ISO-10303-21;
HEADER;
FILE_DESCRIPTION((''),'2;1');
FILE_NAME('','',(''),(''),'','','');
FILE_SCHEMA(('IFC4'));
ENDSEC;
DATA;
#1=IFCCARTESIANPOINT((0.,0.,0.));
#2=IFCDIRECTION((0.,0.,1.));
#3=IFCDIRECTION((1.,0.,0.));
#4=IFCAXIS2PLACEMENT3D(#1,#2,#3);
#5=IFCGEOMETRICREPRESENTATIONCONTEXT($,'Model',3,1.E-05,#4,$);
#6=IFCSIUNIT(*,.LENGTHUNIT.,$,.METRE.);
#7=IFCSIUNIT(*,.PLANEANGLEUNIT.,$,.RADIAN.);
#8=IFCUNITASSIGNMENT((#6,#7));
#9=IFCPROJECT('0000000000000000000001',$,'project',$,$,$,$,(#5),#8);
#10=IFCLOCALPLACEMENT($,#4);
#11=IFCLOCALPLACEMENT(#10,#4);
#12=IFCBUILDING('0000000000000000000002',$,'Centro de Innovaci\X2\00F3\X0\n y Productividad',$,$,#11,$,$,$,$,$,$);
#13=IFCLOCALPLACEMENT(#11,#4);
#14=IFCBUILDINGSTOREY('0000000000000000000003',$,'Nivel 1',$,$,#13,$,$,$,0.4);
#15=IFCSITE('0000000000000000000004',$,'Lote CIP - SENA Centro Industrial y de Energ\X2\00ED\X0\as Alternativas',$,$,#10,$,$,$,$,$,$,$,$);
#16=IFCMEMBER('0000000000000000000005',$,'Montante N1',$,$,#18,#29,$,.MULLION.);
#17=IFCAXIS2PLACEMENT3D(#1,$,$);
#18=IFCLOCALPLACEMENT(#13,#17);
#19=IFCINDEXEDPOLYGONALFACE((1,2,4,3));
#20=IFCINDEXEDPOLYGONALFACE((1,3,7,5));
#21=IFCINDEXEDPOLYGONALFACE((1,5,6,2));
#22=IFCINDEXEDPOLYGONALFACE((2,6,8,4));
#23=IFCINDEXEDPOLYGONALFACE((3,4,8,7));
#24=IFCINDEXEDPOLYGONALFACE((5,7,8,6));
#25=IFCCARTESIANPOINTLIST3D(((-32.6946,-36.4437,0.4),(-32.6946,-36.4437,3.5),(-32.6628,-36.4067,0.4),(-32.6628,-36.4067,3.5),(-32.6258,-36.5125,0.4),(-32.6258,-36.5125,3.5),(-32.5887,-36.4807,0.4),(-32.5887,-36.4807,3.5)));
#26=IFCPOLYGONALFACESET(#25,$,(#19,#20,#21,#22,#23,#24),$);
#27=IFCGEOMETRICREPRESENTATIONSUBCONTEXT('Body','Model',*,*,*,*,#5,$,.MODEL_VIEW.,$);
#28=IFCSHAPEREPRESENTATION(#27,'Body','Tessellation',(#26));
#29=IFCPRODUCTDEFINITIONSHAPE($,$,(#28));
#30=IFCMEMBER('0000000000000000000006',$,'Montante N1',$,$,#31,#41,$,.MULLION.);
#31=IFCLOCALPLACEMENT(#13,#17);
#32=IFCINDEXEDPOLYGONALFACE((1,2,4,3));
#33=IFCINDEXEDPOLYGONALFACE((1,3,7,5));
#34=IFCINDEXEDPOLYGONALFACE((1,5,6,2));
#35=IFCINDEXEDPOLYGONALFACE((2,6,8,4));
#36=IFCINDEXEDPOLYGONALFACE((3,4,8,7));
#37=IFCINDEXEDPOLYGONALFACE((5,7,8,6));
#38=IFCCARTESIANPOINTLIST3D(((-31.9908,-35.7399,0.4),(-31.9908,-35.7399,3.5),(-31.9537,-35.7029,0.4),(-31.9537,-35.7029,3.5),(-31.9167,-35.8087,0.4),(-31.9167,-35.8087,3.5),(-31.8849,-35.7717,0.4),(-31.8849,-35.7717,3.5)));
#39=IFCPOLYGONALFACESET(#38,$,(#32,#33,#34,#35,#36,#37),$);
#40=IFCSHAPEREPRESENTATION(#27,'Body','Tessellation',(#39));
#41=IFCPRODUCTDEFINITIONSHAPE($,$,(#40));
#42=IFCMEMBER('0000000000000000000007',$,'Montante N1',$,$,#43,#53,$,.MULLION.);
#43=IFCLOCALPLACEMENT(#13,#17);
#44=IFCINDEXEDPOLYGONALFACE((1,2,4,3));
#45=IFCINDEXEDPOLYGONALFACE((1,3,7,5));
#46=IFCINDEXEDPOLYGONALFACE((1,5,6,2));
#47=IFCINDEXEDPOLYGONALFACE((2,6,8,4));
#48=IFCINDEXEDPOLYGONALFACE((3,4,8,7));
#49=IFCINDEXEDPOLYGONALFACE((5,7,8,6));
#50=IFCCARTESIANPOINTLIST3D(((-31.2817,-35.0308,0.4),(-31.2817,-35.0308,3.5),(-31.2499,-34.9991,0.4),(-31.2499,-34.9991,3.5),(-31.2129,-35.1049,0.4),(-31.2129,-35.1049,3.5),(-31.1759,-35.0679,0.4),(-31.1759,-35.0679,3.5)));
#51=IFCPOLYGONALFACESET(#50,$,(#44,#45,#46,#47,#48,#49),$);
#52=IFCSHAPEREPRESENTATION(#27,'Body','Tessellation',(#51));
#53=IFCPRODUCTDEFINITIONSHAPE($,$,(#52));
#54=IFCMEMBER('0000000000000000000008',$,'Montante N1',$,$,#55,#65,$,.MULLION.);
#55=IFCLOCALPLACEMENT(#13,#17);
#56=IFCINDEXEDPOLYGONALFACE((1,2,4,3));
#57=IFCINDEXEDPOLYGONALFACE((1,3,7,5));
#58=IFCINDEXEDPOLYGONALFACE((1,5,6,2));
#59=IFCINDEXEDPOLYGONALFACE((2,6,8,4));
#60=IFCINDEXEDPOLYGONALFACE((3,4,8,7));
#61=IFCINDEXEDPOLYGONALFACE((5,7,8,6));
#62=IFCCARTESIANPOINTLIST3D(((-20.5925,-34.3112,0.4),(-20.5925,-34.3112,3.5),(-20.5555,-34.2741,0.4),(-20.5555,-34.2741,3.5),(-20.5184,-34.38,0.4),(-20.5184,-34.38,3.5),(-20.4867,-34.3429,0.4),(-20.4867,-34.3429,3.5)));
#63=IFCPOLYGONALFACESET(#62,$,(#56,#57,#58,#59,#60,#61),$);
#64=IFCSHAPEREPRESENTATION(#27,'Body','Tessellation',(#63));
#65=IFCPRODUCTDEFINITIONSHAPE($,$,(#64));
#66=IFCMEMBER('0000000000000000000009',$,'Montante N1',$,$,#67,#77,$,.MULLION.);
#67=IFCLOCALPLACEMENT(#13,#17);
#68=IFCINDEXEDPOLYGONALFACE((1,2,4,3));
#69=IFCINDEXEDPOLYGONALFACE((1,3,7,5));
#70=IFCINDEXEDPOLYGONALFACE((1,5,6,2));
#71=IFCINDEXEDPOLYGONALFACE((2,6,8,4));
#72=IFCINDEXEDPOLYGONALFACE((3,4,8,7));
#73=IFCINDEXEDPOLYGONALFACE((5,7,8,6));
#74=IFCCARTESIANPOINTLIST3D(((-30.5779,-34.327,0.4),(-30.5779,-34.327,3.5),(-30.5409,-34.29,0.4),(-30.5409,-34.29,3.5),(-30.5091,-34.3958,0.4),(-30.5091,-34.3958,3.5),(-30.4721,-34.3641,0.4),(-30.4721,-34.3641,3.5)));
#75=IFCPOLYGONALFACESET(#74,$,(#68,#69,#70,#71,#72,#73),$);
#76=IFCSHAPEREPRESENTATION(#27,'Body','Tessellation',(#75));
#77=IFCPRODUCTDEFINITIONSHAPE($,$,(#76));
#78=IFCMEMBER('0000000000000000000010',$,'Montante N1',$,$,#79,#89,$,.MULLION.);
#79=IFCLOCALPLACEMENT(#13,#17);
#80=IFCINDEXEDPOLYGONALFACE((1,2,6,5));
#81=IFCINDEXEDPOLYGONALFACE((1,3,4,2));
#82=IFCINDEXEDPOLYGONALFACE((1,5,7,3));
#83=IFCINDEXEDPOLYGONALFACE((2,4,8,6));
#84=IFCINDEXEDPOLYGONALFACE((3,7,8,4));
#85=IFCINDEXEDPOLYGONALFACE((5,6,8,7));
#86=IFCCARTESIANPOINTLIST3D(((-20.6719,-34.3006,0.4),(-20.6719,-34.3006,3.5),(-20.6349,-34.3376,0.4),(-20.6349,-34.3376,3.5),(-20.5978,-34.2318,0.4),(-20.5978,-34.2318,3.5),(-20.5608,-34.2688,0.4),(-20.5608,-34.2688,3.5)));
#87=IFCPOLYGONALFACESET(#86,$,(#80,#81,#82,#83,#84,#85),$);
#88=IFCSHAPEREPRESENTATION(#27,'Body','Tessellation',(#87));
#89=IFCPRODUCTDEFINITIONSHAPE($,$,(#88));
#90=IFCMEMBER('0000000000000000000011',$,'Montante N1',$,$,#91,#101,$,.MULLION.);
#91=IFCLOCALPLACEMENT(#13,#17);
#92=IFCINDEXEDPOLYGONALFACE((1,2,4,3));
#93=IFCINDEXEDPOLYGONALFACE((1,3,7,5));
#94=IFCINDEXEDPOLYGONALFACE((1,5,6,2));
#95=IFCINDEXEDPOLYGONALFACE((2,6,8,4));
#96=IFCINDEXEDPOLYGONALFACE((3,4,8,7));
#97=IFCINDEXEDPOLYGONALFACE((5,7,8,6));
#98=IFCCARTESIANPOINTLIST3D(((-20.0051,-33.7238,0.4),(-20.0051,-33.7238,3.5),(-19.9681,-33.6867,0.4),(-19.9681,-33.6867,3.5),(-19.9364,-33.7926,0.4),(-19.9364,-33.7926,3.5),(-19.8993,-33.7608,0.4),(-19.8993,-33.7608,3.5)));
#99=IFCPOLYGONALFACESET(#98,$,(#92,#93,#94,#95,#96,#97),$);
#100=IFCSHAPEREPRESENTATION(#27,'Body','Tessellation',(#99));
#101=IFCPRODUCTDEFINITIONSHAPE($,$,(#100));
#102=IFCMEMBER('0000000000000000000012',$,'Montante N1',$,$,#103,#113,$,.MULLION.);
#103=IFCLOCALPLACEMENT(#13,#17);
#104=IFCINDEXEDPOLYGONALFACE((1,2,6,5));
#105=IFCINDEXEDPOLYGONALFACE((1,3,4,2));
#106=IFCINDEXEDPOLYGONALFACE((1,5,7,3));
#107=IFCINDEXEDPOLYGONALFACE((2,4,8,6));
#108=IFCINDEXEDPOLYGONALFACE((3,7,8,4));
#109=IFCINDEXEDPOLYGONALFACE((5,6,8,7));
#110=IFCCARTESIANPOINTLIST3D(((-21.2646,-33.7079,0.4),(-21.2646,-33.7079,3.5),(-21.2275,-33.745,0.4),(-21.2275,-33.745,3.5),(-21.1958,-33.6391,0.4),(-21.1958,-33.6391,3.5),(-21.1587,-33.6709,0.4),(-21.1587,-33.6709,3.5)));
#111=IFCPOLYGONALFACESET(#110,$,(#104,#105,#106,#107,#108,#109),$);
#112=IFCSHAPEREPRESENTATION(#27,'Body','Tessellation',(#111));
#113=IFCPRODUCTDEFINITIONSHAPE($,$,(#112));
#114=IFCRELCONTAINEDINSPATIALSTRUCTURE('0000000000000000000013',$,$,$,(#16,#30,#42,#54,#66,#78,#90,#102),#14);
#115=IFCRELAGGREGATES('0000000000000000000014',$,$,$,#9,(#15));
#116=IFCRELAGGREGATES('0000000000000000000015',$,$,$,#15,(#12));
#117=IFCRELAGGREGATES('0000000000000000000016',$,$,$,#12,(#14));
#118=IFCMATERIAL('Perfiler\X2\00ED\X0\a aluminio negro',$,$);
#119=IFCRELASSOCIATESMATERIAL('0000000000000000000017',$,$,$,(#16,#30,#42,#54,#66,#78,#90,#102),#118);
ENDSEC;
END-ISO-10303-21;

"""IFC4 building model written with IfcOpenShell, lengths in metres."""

from ifc_helpers import new_model, si_unit, frame, origin_with_axes, place, context, subcontext, project, spatial, polyline, outline, extrude, material, element, save


model = new_model("IFC4")

# Units and contexts
model_context = context("Model", 3, precision=1e-05, world=origin_with_axes())
body_context = subcontext(model_context, "Body", "Model", "MODEL_VIEW")
ifc_project = project(units=[si_unit("LENGTHUNIT", "METRE"), si_unit("PLANEANGLEUNIT", "RADIAN")], contexts=[model_context])

# Site, building, storey
site_placement = place(None, origin_with_axes())
site = spatial("IfcSite", under=ifc_project, at=site_placement, Name="Lote CIP - SENA Centro Industrial y de Energías Alternativas")
building_placement = place(site_placement, origin_with_axes())
building = spatial("IfcBuilding", under=site, at=building_placement, Name="Centro de Innovación y Productividad")
storey_placement = place(building_placement, origin_with_axes())
storey = spatial("IfcBuildingStorey", under=building, at=storey_placement, Name="Nivel 1", Elevation=0.4)

# Members
ifc_material = material(Name="Perfilería aluminio negro")
member_1_placement = place(storey_placement, origin_with_axes())
element("IfcMember", 1, at=member_1_placement, inside=storey, material=ifc_material, Name="Montante N1", PredefinedType="MULLION", context=body_context, shape_type="SweptSolid", body=[
    extrude(outline(polyline([(-32.6946, -36.4437), (-32.6628, -36.4067), (-32.5887, -36.4807), (-32.6258, -36.5125), (-32.6946, -36.4437)])), frame((0.0, 0.0, 0.4)), (0.0, 0.0, 1.0), 3.1),
])
member_2_placement = place(storey_placement, origin_with_axes())
element("IfcMember", 2, at=member_2_placement, inside=storey, material=ifc_material, Name="Montante N1", PredefinedType="MULLION", context=body_context, shape_type="SweptSolid", body=[
    extrude(outline(polyline([(-31.9167, -35.8087), (-31.9908, -35.7399), (-31.9537, -35.7029), (-31.8849, -35.7717), (-31.9167, -35.8087)])), frame((0.0, 0.0, 0.4)), (0.0, 0.0, 1.0), 3.1),
])
member_3_placement = place(storey_placement, origin_with_axes())
element("IfcMember", 3, at=member_3_placement, inside=storey, material=ifc_material, Name="Montante N1", PredefinedType="MULLION", context=body_context, shape_type="SweptSolid", body=[
    extrude(outline(polyline([(-31.2499, -34.9991), (-31.1759, -35.0679), (-31.2129, -35.1049), (-31.2817, -35.0308), (-31.2499, -34.9991)])), frame((0.0, 0.0, 0.4)), (0.0, 0.0, 1.0), 3.1),
])
member_4_placement = place(storey_placement, origin_with_axes())
element("IfcMember", 4, at=member_4_placement, inside=storey, material=ifc_material, Name="Montante N1", PredefinedType="MULLION", context=body_context, shape_type="SweptSolid", body=[
    extrude(outline(polyline([(-20.4867, -34.3429), (-20.5184, -34.38), (-20.5925, -34.3112), (-20.5555, -34.2741), (-20.4867, -34.3429)])), frame((0.0, 0.0, 0.4)), (0.0, 0.0, 1.0), 3.1),
])
member_5_placement = place(storey_placement, origin_with_axes())
element("IfcMember", 5, at=member_5_placement, inside=storey, material=ifc_material, Name="Montante N1", PredefinedType="MULLION", context=body_context, shape_type="SweptSolid", body=[
    extrude(outline(polyline([(-30.5409, -34.29), (-30.4721, -34.3641), (-30.5091, -34.3958), (-30.5779, -34.327), (-30.5409, -34.29)])), frame((0.0, 0.0, 0.4)), (0.0, 0.0, 1.0), 3.1),
])
member_6_placement = place(storey_placement, origin_with_axes())
element("IfcMember", 6, at=member_6_placement, inside=storey, material=ifc_material, Name="Montante N1", PredefinedType="MULLION", context=body_context, shape_type="SweptSolid", body=[
    extrude(outline(polyline([(-20.5608, -34.2688), (-20.6349, -34.3376), (-20.6719, -34.3006), (-20.5978, -34.2318), (-20.5608, -34.2688)])), frame((0.0, 0.0, 0.4)), (0.0, 0.0, 1.0), 3.1),
])
member_7_placement = place(storey_placement, origin_with_axes())
element("IfcMember", 7, at=member_7_placement, inside=storey, material=ifc_material, Name="Montante N1", PredefinedType="MULLION", context=body_context, shape_type="SweptSolid", body=[
    extrude(outline(polyline([(-20.0051, -33.7238), (-19.9681, -33.6867), (-19.8993, -33.7608), (-19.9364, -33.7926), (-20.0051, -33.7238)])), frame((0.0, 0.0, 0.4)), (0.0, 0.0, 1.0), 3.1),
])
member_8_placement = place(storey_placement, origin_with_axes())
element("IfcMember", 8, at=member_8_placement, inside=storey, material=ifc_material, Name="Montante N1", PredefinedType="MULLION", context=body_context, shape_type="SweptSolid", body=[
    extrude(outline(polyline([(-21.2275, -33.745), (-21.2646, -33.7079), (-21.1958, -33.6391), (-21.1587, -33.6709), (-21.2275, -33.745)])), frame((0.0, 0.0, 0.4)), (0.0, 0.0, 1.0), 3.1),
])

save(model, "model.ifc")
